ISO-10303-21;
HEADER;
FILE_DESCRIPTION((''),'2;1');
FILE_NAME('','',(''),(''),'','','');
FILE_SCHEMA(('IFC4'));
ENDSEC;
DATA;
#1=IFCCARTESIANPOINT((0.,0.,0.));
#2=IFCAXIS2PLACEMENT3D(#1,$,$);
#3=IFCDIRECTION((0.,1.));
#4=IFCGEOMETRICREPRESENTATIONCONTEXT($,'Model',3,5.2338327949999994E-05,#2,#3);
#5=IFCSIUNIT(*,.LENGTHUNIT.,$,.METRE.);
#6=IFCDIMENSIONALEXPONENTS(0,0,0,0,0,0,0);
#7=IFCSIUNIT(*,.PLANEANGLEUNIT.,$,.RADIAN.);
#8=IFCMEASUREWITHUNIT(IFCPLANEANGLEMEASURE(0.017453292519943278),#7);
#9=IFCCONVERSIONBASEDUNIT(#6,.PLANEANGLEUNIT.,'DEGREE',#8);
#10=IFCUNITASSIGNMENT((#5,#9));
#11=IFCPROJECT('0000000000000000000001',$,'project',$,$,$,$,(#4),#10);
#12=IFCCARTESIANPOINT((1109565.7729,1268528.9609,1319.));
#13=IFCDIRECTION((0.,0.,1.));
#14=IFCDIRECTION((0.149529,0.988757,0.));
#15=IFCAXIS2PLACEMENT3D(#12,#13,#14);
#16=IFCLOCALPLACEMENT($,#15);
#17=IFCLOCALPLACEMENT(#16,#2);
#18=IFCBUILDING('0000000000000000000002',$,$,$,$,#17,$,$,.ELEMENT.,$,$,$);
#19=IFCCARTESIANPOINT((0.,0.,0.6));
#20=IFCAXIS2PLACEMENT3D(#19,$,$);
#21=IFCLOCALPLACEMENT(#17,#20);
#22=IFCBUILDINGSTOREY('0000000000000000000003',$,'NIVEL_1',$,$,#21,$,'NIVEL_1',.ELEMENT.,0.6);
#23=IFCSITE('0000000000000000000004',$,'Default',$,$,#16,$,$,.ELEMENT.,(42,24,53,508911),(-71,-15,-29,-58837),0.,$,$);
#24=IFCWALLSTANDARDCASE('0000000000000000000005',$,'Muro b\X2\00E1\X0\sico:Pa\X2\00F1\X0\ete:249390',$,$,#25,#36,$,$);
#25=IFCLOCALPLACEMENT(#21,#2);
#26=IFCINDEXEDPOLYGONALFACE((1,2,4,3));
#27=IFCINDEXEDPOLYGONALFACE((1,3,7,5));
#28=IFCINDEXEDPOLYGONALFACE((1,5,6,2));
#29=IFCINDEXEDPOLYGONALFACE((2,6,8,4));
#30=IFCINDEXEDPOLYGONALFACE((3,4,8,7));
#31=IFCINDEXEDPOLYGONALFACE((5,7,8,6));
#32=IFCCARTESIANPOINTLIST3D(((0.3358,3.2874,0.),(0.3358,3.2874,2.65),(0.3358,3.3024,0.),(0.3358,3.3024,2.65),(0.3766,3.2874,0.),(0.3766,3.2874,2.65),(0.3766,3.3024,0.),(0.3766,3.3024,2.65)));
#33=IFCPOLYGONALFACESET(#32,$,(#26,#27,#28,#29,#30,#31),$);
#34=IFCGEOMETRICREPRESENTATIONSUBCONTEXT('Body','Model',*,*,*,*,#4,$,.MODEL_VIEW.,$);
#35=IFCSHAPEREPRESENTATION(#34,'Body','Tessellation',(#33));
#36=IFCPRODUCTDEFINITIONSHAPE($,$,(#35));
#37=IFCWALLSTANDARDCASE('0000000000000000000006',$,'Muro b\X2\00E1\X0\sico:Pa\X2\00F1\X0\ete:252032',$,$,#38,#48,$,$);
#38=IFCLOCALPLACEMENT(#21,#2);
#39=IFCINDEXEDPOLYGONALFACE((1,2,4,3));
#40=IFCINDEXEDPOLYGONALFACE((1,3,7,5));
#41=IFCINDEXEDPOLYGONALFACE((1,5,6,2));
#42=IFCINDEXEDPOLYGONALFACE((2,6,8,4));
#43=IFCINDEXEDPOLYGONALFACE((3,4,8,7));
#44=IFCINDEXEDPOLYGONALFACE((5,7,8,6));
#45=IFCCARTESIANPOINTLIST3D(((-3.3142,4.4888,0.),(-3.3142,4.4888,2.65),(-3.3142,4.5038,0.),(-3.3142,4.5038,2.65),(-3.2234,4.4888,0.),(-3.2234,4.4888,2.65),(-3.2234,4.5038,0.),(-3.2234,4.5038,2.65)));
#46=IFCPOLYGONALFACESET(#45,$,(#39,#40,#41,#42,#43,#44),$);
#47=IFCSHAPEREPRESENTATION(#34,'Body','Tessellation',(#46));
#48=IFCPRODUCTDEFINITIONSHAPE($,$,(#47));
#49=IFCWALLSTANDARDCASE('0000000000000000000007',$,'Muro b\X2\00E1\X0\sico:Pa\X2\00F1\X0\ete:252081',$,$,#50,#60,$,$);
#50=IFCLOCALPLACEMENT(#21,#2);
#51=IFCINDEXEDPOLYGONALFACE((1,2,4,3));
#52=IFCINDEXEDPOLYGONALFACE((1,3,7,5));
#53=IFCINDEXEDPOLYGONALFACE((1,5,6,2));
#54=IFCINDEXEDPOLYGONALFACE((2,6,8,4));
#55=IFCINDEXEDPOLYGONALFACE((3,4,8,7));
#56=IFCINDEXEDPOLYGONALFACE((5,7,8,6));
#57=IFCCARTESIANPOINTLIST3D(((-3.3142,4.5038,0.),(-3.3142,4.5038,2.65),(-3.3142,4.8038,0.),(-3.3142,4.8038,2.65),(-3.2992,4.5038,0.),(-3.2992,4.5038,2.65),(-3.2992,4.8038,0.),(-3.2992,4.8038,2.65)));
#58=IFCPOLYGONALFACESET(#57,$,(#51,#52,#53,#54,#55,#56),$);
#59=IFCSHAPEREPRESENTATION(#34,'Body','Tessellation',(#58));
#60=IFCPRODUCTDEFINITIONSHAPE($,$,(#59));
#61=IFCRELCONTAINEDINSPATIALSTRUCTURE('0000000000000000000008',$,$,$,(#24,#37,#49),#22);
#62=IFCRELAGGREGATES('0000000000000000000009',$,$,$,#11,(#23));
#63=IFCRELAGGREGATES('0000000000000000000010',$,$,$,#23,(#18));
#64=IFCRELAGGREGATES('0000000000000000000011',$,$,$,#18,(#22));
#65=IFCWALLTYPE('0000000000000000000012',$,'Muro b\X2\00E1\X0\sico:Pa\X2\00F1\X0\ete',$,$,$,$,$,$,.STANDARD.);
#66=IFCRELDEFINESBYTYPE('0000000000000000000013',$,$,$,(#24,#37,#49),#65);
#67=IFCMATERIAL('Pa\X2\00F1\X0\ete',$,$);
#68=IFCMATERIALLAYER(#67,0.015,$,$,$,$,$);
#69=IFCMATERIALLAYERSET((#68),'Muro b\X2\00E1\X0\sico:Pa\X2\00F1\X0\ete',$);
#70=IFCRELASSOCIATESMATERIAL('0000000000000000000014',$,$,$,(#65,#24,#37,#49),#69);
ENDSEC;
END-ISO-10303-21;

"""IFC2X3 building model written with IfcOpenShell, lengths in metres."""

from ifc_helpers import new_model, entity, si_unit, converted_unit, direction, frame, frame_2d, origin, place, context, subcontext, project, spatial, rectangle, extrude, material, layer, layer_set, layer_usage, type_object, element, save


model = new_model("IFC2X3")

# Units and contexts
model_context = context("Model", 3, precision=5.2338327949999994e-05, world=origin(), true_north=direction((0.0, 1.0)))
body_context = subcontext(model_context, "Body", "Model", "MODEL_VIEW")
ifc_project = project(units=[si_unit("LENGTHUNIT", "METRE"), converted_unit("PLANEANGLEUNIT", "DEGREE", entity("IfcPlaneAngleMeasure", 0.017453292519943278), si_unit("PLANEANGLEUNIT", "RADIAN"), dimensions=[0, 0, 0, 0, 0, 0, 0])], contexts=[model_context])

# Site, building, storey
site_placement = place(None, frame((1109565.7729, 1268528.9609, 1319.0), z_axis=(0.0, 0.0, 1.0), x_axis=(0.149529, 0.988757, 0.0)))
site = spatial("IfcSite", under=ifc_project, at=site_placement, Name="Default", CompositionType="ELEMENT", RefLatitude=(42, 24, 53, 508911), RefLongitude=(-71, -15, -29, -58837), RefElevation=0.0)
building_placement = place(site_placement, origin())
building = spatial("IfcBuilding", under=site, at=building_placement, CompositionType="ELEMENT")
storey_placement = place(building_placement, frame((0.0, 0.0, 0.6)))
storey = spatial("IfcBuildingStorey", under=building, at=storey_placement, Name="NIVEL_1", LongName="NIVEL_1", CompositionType="ELEMENT", Elevation=0.6)

# Shared definitions
ifc_material_1 = material(Name="Pañete")

# Walls
ifc_layer_1 = layer(ifc_material_1, 0.015)
ifc_layer_set_1 = layer_set([ifc_layer_1], Name="Muro básico:Pañete")
wall_type_1 = type_object("IfcWallType", Name="Muro básico:Pañete", PredefinedType="STANDARD", material=ifc_layer_set_1)
ifc_layer_usage_1 = layer_usage(ifc_layer_set_1, "AXIS2", "POSITIVE", -0.0075)
wall_1_placement = place(storey_placement, frame((0.3358, 3.2949, 0.0)))
element("IfcWallStandardCase", 1, at=wall_1_placement, inside=storey, type_object=wall_type_1, material=ifc_layer_usage_1, Name="Muro básico:Pañete:249390", context=body_context, shape_type="SweptSolid", body=[
    extrude(rectangle(XDim=0.0409, YDim=0.015, at=frame_2d((0.0204, 0.0), x_axis=(-1.0, 0.0))), origin(), (0.0, 0.0, 1.0), 2.65),
])
ifc_layer_usage_2 = layer_usage(ifc_layer_set_1, "AXIS2", "NEGATIVE", 0.0075)
wall_2_placement = place(storey_placement, frame((-3.2234, 4.4963, 0.0), z_axis=(0.0, 0.0, 1.0), x_axis=(-1.0, 0.0, 0.0)))
element("IfcWallStandardCase", 2, at=wall_2_placement, inside=storey, type_object=wall_type_1, material=ifc_layer_usage_2, Name="Muro básico:Pañete:252032", context=body_context, shape_type="SweptSolid", body=[
    extrude(rectangle(XDim=0.0909, YDim=0.015, at=frame_2d((0.0454, 0.0), x_axis=(-1.0, 0.0))), origin(), (0.0, 0.0, 1.0), 2.65),
])
ifc_layer_usage_3 = layer_usage(ifc_layer_set_1, "AXIS2", "NEGATIVE", 0.0075)
wall_3_placement = place(storey_placement, frame((-3.3067, 4.5038, 0.0), z_axis=(0.0, 0.0, 1.0), x_axis=(0.0, 1.0, 0.0)))
element("IfcWallStandardCase", 3, at=wall_3_placement, inside=storey, type_object=wall_type_1, material=ifc_layer_usage_3, Name="Muro básico:Pañete:252081", context=body_context, shape_type="SweptSolid", body=[
    extrude(rectangle(XDim=0.3, YDim=0.015, at=frame_2d((0.15, 0.0), x_axis=(-1.0, 0.0))), origin(), (0.0, 0.0, 1.0), 2.65),
])

save(model, "model.ifc")
